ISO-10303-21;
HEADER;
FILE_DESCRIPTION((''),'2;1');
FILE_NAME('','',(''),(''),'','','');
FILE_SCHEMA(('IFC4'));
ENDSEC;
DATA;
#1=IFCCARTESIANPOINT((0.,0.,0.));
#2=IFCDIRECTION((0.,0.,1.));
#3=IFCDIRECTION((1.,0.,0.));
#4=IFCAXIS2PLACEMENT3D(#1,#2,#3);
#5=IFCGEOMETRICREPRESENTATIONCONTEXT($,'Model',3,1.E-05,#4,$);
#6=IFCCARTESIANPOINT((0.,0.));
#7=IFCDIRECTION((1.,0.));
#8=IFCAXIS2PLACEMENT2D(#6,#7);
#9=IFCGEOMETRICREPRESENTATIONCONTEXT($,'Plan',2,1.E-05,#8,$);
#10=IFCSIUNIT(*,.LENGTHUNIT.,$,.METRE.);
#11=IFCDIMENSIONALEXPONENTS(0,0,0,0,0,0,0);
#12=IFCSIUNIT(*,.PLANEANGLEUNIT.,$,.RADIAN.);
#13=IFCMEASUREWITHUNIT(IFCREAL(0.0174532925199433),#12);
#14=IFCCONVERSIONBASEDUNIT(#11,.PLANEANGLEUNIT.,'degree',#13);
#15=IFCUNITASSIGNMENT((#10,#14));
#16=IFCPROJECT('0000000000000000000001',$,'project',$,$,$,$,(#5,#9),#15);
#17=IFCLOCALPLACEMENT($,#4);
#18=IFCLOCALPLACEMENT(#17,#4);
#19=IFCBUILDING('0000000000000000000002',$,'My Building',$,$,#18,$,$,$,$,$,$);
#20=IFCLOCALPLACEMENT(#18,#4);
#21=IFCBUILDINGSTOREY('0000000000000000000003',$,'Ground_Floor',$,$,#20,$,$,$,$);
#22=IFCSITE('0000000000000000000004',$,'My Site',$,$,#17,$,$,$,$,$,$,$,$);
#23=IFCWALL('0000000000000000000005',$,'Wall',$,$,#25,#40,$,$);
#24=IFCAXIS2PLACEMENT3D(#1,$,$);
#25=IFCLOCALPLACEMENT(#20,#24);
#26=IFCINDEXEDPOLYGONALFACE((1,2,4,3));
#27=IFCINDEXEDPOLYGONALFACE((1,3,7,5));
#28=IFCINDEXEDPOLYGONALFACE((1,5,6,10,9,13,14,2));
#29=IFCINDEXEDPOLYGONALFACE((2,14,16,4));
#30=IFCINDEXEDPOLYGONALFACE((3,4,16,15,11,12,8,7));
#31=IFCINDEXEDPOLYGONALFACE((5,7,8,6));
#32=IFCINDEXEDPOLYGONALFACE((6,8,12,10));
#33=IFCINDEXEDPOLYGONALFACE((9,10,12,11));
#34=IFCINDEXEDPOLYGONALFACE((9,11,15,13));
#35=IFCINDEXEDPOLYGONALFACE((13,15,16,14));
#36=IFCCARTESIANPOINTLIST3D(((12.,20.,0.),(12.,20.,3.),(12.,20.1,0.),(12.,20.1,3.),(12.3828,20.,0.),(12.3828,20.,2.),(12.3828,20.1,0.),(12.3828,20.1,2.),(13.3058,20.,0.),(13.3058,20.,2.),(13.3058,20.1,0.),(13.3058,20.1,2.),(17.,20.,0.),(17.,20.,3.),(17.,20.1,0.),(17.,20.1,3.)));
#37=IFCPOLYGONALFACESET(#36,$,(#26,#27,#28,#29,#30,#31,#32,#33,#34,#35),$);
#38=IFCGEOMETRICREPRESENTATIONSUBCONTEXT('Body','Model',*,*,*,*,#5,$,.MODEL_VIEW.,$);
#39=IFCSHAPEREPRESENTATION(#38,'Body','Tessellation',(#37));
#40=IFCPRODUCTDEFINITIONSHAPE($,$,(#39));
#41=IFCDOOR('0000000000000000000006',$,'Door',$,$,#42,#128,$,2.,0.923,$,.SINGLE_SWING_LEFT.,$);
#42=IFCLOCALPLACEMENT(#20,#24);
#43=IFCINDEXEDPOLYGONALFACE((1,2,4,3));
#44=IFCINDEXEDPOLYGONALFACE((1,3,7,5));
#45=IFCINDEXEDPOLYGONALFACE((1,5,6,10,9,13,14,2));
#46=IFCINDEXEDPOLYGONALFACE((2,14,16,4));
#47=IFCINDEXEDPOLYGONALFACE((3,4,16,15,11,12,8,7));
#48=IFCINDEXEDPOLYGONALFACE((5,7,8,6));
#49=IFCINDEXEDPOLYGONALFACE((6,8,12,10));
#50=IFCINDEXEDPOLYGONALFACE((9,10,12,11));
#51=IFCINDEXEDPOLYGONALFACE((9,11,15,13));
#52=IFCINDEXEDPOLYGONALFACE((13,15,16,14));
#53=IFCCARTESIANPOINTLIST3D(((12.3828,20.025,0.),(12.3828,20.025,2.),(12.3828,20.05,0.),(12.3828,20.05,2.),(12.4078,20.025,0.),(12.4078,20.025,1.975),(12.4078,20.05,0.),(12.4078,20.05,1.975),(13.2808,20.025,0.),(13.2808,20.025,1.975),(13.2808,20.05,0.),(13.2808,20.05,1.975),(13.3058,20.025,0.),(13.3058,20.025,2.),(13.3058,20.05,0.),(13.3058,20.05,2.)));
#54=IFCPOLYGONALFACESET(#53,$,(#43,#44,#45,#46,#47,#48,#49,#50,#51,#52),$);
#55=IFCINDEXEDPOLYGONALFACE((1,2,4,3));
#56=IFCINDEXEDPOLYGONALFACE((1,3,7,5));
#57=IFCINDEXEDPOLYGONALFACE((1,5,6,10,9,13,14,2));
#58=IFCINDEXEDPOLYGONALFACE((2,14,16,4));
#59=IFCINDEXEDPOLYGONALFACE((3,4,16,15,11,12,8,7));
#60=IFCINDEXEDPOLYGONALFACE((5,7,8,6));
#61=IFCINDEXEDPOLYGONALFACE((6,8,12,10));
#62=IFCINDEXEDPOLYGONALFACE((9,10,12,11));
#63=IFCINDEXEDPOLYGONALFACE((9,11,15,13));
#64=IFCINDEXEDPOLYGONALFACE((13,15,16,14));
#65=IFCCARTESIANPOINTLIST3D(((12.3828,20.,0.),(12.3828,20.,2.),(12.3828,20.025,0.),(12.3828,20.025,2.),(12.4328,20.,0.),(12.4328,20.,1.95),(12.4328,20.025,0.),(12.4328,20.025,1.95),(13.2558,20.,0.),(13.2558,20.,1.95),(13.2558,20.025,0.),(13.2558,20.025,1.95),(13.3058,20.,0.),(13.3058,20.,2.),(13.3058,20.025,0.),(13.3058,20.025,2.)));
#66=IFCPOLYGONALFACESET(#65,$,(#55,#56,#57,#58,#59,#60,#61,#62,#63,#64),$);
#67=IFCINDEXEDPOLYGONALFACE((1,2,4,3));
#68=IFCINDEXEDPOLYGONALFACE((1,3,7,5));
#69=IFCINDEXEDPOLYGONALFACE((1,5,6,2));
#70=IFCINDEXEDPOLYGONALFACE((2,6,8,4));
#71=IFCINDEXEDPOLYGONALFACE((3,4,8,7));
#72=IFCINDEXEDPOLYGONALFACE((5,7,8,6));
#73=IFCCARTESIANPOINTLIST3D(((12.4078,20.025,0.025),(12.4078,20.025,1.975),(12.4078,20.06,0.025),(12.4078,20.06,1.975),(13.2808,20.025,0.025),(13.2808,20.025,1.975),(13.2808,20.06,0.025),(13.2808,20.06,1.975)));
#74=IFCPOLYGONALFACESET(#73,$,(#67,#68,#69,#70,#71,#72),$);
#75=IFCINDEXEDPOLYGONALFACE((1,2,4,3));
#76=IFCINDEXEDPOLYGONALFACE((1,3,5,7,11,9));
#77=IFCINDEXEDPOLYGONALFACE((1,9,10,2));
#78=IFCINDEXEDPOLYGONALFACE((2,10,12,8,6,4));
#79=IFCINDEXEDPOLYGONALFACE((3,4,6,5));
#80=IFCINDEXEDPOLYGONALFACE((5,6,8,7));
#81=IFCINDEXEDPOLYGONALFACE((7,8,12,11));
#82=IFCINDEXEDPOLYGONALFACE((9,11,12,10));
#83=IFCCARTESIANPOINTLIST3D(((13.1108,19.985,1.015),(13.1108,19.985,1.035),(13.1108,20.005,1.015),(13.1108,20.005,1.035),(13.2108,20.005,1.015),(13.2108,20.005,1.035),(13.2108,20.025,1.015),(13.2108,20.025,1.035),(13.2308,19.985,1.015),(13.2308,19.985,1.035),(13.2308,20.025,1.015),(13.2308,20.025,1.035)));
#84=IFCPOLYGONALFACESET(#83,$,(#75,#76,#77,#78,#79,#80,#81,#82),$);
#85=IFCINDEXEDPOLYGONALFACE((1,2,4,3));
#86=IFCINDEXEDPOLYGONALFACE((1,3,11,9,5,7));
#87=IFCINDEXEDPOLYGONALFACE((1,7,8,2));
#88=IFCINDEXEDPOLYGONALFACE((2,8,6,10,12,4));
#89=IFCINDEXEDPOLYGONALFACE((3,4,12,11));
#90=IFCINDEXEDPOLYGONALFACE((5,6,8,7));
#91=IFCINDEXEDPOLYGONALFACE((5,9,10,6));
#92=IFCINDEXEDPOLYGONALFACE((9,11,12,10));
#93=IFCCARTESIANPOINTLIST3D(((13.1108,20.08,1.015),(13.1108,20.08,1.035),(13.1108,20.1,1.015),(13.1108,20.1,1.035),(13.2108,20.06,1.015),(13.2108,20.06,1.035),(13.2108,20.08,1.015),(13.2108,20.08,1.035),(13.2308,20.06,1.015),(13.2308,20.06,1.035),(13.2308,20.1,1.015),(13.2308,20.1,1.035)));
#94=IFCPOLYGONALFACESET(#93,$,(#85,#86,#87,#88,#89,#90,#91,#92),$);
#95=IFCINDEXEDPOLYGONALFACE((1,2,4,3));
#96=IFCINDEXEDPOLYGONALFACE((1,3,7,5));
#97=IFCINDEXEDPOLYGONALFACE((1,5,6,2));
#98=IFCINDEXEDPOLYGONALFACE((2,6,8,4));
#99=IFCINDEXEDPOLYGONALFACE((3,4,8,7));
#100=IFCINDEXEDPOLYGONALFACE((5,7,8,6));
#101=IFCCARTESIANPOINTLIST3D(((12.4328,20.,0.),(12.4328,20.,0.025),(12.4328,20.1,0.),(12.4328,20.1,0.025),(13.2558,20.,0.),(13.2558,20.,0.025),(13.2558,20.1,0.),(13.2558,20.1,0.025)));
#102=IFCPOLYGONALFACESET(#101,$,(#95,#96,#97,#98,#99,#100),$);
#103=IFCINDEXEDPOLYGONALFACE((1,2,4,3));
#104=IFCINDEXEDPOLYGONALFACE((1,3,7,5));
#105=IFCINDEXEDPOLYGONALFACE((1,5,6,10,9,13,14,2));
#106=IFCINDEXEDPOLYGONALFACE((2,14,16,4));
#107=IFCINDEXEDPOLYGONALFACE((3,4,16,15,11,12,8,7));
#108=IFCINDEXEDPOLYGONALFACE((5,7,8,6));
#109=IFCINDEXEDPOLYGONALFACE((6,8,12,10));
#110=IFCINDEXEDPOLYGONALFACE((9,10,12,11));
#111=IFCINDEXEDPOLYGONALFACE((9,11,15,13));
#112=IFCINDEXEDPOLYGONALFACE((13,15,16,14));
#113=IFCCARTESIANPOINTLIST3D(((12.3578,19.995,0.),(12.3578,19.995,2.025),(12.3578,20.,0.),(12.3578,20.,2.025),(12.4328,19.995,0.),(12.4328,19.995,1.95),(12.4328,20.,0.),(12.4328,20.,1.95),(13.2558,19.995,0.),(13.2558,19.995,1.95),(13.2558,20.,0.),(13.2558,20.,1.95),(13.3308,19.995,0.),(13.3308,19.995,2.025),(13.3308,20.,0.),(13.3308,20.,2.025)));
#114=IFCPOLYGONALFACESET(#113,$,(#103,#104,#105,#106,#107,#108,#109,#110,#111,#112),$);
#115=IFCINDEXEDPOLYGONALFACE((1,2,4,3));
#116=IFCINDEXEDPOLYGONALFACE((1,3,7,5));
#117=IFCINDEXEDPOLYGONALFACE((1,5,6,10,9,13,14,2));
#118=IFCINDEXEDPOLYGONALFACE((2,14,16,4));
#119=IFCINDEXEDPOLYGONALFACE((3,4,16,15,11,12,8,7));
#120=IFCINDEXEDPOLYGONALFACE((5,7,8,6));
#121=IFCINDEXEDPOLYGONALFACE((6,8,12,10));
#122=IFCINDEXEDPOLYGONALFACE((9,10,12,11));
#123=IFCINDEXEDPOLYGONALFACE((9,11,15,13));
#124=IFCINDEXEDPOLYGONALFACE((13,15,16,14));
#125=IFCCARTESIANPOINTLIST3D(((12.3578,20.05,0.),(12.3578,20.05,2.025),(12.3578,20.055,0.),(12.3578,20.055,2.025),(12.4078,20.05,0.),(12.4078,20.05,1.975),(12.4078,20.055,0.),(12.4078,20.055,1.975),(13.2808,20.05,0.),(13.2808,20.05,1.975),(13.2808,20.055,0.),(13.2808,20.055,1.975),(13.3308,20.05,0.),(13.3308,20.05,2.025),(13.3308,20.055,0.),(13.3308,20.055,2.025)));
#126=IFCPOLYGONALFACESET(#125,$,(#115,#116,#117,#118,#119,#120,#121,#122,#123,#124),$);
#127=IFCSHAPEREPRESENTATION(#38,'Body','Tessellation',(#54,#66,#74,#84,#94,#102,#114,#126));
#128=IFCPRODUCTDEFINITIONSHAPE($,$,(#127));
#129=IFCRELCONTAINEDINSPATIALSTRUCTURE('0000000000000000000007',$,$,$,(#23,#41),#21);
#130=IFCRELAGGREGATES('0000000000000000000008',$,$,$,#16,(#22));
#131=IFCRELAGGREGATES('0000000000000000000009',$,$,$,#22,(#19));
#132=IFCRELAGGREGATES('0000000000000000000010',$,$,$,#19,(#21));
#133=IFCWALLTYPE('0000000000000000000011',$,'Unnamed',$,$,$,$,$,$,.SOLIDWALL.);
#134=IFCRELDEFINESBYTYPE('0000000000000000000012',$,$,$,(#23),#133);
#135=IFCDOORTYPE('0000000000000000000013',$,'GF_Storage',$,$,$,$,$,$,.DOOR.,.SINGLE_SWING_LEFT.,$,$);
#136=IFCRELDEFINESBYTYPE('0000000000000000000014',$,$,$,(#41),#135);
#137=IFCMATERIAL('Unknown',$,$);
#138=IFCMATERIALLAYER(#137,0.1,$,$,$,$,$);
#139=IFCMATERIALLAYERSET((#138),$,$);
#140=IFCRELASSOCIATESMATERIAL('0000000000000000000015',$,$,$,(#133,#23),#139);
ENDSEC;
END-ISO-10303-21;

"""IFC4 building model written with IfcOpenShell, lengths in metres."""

from ifc_helpers import new_model, entity, si_unit, converted_unit, frame, origin_with_axes, origin_2d_with_axis, place, context, subcontext, project, spatial, line, indexed_curve, outline, extrude, shape, source, transform, mapped, material, layer, layer_set, layer_usage, type_object, type_shapes, element, fill, save


model = new_model("IFC4")

# Units and contexts
model_context = context("Model", 3, precision=1e-05, world=origin_with_axes())
plan_context = context("Plan", 2, precision=1e-05, world=origin_2d_with_axis())
body_context_1 = subcontext(model_context, "Body", "Model", "MODEL_VIEW")
body_context_2 = subcontext(plan_context, "Body", "Plan", "PLAN_VIEW")
ifc_project = project(units=[si_unit("LENGTHUNIT", "METRE"), converted_unit("PLANEANGLEUNIT", "degree", entity("IfcReal", 0.0174532925199433), si_unit("PLANEANGLEUNIT", "RADIAN"), dimensions=[0, 0, 0, 0, 0, 0, 0])], contexts=[model_context, plan_context])

# Site, building, storey
site_placement = place(None, origin_with_axes())
site = spatial("IfcSite", under=ifc_project, at=site_placement, Name="My Site")
building_placement = place(site_placement, origin_with_axes())
building = spatial("IfcBuilding", under=site, at=building_placement, Name="My Building")
storey_placement = place(building_placement, origin_with_axes())
storey = spatial("IfcBuildingStorey", under=building, at=storey_placement, Name="Ground_Floor")

# Shared definitions
ifc_material = material(Name="Unknown")

# Shared definitions
ifc_layer_1 = layer(ifc_material, 0.1)
ifc_layer_set_1 = layer_set([ifc_layer_1])
wall_type = type_object("IfcWallType", Name="Unnamed", PredefinedType="SOLIDWALL", material=ifc_layer_set_1)
shared_shape_1 = source(origin_with_axes(), body_context_1, "Body", "SweptSolid", [
    extrude(outline(indexed_curve([(0.0, 0.0), (0.923, 0.0), (0.923, 2.0), (0.0, 2.0)], segments=[line(1, 2, 3, 4, 1)])), frame((0.0, -0.6, 0.0), z_axis=(0.0, -1.0, 0.0), x_axis=(1.0, 0.0, 0.0)), (0.0, 0.0, -1.0), 1.2),
])
door_type_1 = type_object("IfcDoorType", Name="GF_Storage", OperationType="SINGLE_SWING_LEFT", PredefinedType="DOOR")
shared_shape_2 = source(origin_with_axes(), body_context_1, "Body", "SweptSolid", [
    extrude(outline(indexed_curve([(0.0, 0.0), (0.0, 2.0), (0.923, 2.0), (0.923, 0.0), (0.898, 0.0), (0.898, 1.975), (0.025, 1.975), (0.025, 0.0)], segments=[line(1, 2, 3, 4, 5, 6, 7, 8, 1)])), frame((0.0, 0.025, 0.0), z_axis=(0.0, -1.0, 0.0), x_axis=(1.0, 0.0, 0.0)), (0.0, 0.0, -1.0), 0.025),
    extrude(outline(indexed_curve([(0.0, 0.0), (0.0, 2.0), (0.923, 2.0), (0.923, 0.0), (0.873, 0.0), (0.873, 1.95), (0.05, 1.95), (0.05, 0.0)], segments=[line(1, 2, 3, 4, 5, 6, 7, 8, 1)])), frame((0.0, 0.0, 0.0), z_axis=(0.0, -1.0, 0.0), x_axis=(1.0, 0.0, 0.0)), (0.0, 0.0, -1.0), 0.025),
    extrude(outline(indexed_curve([(0.0, 0.0), (0.873, 0.0), (0.873, 0.035), (0.0, 0.035)], segments=[line(1, 2, 3, 4, 1)])), frame((0.025, 0.025, 0.025), z_axis=(0.0, 0.0, 1.0), x_axis=(1.0, 0.0, 0.0)), (0.0, 0.0, 1.0), 1.95),
    extrude(outline(indexed_curve([(0.0, 0.0), (0.0, -0.04), (-0.12, -0.04), (-0.12, -0.02), (-0.02, -0.02), (-0.02, 0.0)], segments=[line(1, 2, 3, 4, 5, 6, 1)])), frame((0.848, 0.025, 1.015), z_axis=(0.0, 0.0, 1.0), x_axis=(1.0, 0.0, 0.0)), (0.0, 0.0, 1.0), 0.02),
    extrude(outline(indexed_curve([(0.0, 0.0), (0.0, 0.04), (-0.12, 0.04), (-0.12, 0.02), (-0.02, 0.02), (-0.02, 0.0)], segments=[line(1, 2, 3, 4, 5, 6, 1)])), frame((0.848, 0.06, 1.015), z_axis=(0.0, 0.0, 1.0), x_axis=(1.0, 0.0, 0.0)), (0.0, 0.0, 1.0), 0.02),
    extrude(outline(indexed_curve([(0.0, 0.0), (0.823, 0.0), (0.823, 0.1), (0.0, 0.1)], segments=[line(1, 2, 3, 4, 1)])), frame((0.05, 0.0, 0.0), z_axis=(0.0, 0.0, 1.0), x_axis=(1.0, 0.0, 0.0)), (0.0, 0.0, 1.0), 0.025),
    extrude(outline(indexed_curve([(0.0, 0.0), (0.0, 2.025), (0.973, 2.025), (0.973, 0.0), (0.898, 0.0), (0.898, 1.95), (0.075, 1.95), (0.075, 0.0)], segments=[line(1, 2, 3, 4, 5, 6, 7, 8, 1)])), frame((-0.025, -0.005, 0.0), z_axis=(0.0, -1.0, 0.0), x_axis=(1.0, 0.0, 0.0)), (0.0, 0.0, -1.0), 0.005),
    extrude(outline(indexed_curve([(0.0, 0.0), (0.0, 2.025), (0.973, 2.025), (0.973, 0.0), (0.923, 0.0), (0.923, 1.975), (0.05, 1.975), (0.05, 0.0)], segments=[line(1, 2, 3, 4, 5, 6, 7, 8, 1)])), frame((-0.025, 0.05, 0.0), z_axis=(0.0, -1.0, 0.0), x_axis=(1.0, 0.0, 0.0)), (0.0, 0.0, -1.0), 0.005),
])
shared_shape_3 = source(origin_with_axes(), body_context_2, "Body", "Curve2D", [
    entity("IfcIndexedPolyCurve", entity("IfcCartesianPointList2D", [[0.0, 0.0], [0.0, 0.05], [0.025, 0.05], [0.025, 0.025], [0.05, 0.025], [0.05, 0.0]]), [entity("IfcLineIndex", [1, 2, 3, 4, 5, 6, 1])]),
    entity("IfcIndexedPolyCurve", entity("IfcCartesianPointList2D", [[0.923, 0.0], [0.923, 0.05], [0.898, 0.05], [0.898, 0.025], [0.873, 0.025], [0.873, 0.0]]), [entity("IfcLineIndex", [1, 2, 3, 4, 5, 6, 1])]),
    entity("IfcTrimmedCurve", entity("IfcEllipse", entity("IfcAxis2Placement2D", entity("IfcCartesianPoint", [0.06, 0.05]), entity("IfcDirection", [1.0, 0.0])), 0.838, 0.873), [entity("IfcCartesianPoint", [0.898, 0.05])], [entity("IfcCartesianPoint", [0.06, 0.923])], True, "CARTESIAN"),
    entity("IfcIndexedPolyCurve", entity("IfcCartesianPointList2D", [[0.025, 0.05], [0.06, 0.05], [0.06, 0.923], [0.025, 0.923]]), [entity("IfcLineIndex", [1, 2, 3, 4, 1])]),
])
type_shapes(door_type_1, [shared_shape_2, shared_shape_3])

# Wall, opening, door
ifc_layer_usage_1 = layer_usage(ifc_layer_set_1, "AXIS2", "POSITIVE", 0.0)
wall_1_placement = place(storey_placement, frame((12.0, 20.0, 0.0), z_axis=(0.0, 0.0, 1.0), x_axis=(1.0, 0.0, 0.0)))
wall_1 = element("IfcWall", 1, at=wall_1_placement, inside=storey, type_object=wall_type, material=ifc_layer_usage_1, Name="Wall", context=body_context_1, shape_type="SweptSolid", body=[
    extrude(outline(indexed_curve([(0.0, 0.0), (0.0, 0.1), (5.0, 0.1), (5.0, 0.0)], segments=[line(1, 2, 3, 4, 1)])), origin_with_axes(), (0.0, 0.0, 1.0), 3.0),
])
opening_1_placement = place(wall_1_placement, frame((0.3828, 0.0, 0.0), z_axis=(0.0, 0.0, 1.0), x_axis=(1.0, 0.0, 0.0)))
opening_1 = element("IfcOpeningElement", 2, at=opening_1_placement, cuts=wall_1, PredefinedType="OPENING", context=body_context_1, shape_type="MappedRepresentation", body=[
    mapped(shared_shape_1, transform((0.0, 0.0, 0.0), x_axis=(1.0, 0.0, 0.0), y_axis=(0.0, 1.0, 0.0), z_axis=(0.0, 0.0, 1.0), scale=1.0)),
])
door_1_placement = place(opening_1_placement, origin_with_axes())
door_1 = element("IfcDoor", 3, at=door_1_placement, inside=storey, type_object=door_type_1, Name="Door", OperationType="SINGLE_SWING_LEFT", OverallHeight=2.0, OverallWidth=0.923, shapes=[
    shape(body_context_1, "Body", "MappedRepresentation", [mapped(shared_shape_2, transform((0.0, 0.0, 0.0), x_axis=(1.0, 0.0, 0.0), y_axis=(0.0, 1.0, 0.0), z_axis=(0.0, 0.0, 1.0), scale=1.0))]),
    shape(body_context_2, "Body", "MappedRepresentation", [mapped(shared_shape_3, transform((0.0, 0.0, 0.0), x_axis=(1.0, 0.0, 0.0), y_axis=(0.0, 1.0, 0.0), z_axis=(0.0, 0.0, 1.0), scale=1.0))]),
])
fill(opening_1, door_1)

save(model, "model.ifc")
